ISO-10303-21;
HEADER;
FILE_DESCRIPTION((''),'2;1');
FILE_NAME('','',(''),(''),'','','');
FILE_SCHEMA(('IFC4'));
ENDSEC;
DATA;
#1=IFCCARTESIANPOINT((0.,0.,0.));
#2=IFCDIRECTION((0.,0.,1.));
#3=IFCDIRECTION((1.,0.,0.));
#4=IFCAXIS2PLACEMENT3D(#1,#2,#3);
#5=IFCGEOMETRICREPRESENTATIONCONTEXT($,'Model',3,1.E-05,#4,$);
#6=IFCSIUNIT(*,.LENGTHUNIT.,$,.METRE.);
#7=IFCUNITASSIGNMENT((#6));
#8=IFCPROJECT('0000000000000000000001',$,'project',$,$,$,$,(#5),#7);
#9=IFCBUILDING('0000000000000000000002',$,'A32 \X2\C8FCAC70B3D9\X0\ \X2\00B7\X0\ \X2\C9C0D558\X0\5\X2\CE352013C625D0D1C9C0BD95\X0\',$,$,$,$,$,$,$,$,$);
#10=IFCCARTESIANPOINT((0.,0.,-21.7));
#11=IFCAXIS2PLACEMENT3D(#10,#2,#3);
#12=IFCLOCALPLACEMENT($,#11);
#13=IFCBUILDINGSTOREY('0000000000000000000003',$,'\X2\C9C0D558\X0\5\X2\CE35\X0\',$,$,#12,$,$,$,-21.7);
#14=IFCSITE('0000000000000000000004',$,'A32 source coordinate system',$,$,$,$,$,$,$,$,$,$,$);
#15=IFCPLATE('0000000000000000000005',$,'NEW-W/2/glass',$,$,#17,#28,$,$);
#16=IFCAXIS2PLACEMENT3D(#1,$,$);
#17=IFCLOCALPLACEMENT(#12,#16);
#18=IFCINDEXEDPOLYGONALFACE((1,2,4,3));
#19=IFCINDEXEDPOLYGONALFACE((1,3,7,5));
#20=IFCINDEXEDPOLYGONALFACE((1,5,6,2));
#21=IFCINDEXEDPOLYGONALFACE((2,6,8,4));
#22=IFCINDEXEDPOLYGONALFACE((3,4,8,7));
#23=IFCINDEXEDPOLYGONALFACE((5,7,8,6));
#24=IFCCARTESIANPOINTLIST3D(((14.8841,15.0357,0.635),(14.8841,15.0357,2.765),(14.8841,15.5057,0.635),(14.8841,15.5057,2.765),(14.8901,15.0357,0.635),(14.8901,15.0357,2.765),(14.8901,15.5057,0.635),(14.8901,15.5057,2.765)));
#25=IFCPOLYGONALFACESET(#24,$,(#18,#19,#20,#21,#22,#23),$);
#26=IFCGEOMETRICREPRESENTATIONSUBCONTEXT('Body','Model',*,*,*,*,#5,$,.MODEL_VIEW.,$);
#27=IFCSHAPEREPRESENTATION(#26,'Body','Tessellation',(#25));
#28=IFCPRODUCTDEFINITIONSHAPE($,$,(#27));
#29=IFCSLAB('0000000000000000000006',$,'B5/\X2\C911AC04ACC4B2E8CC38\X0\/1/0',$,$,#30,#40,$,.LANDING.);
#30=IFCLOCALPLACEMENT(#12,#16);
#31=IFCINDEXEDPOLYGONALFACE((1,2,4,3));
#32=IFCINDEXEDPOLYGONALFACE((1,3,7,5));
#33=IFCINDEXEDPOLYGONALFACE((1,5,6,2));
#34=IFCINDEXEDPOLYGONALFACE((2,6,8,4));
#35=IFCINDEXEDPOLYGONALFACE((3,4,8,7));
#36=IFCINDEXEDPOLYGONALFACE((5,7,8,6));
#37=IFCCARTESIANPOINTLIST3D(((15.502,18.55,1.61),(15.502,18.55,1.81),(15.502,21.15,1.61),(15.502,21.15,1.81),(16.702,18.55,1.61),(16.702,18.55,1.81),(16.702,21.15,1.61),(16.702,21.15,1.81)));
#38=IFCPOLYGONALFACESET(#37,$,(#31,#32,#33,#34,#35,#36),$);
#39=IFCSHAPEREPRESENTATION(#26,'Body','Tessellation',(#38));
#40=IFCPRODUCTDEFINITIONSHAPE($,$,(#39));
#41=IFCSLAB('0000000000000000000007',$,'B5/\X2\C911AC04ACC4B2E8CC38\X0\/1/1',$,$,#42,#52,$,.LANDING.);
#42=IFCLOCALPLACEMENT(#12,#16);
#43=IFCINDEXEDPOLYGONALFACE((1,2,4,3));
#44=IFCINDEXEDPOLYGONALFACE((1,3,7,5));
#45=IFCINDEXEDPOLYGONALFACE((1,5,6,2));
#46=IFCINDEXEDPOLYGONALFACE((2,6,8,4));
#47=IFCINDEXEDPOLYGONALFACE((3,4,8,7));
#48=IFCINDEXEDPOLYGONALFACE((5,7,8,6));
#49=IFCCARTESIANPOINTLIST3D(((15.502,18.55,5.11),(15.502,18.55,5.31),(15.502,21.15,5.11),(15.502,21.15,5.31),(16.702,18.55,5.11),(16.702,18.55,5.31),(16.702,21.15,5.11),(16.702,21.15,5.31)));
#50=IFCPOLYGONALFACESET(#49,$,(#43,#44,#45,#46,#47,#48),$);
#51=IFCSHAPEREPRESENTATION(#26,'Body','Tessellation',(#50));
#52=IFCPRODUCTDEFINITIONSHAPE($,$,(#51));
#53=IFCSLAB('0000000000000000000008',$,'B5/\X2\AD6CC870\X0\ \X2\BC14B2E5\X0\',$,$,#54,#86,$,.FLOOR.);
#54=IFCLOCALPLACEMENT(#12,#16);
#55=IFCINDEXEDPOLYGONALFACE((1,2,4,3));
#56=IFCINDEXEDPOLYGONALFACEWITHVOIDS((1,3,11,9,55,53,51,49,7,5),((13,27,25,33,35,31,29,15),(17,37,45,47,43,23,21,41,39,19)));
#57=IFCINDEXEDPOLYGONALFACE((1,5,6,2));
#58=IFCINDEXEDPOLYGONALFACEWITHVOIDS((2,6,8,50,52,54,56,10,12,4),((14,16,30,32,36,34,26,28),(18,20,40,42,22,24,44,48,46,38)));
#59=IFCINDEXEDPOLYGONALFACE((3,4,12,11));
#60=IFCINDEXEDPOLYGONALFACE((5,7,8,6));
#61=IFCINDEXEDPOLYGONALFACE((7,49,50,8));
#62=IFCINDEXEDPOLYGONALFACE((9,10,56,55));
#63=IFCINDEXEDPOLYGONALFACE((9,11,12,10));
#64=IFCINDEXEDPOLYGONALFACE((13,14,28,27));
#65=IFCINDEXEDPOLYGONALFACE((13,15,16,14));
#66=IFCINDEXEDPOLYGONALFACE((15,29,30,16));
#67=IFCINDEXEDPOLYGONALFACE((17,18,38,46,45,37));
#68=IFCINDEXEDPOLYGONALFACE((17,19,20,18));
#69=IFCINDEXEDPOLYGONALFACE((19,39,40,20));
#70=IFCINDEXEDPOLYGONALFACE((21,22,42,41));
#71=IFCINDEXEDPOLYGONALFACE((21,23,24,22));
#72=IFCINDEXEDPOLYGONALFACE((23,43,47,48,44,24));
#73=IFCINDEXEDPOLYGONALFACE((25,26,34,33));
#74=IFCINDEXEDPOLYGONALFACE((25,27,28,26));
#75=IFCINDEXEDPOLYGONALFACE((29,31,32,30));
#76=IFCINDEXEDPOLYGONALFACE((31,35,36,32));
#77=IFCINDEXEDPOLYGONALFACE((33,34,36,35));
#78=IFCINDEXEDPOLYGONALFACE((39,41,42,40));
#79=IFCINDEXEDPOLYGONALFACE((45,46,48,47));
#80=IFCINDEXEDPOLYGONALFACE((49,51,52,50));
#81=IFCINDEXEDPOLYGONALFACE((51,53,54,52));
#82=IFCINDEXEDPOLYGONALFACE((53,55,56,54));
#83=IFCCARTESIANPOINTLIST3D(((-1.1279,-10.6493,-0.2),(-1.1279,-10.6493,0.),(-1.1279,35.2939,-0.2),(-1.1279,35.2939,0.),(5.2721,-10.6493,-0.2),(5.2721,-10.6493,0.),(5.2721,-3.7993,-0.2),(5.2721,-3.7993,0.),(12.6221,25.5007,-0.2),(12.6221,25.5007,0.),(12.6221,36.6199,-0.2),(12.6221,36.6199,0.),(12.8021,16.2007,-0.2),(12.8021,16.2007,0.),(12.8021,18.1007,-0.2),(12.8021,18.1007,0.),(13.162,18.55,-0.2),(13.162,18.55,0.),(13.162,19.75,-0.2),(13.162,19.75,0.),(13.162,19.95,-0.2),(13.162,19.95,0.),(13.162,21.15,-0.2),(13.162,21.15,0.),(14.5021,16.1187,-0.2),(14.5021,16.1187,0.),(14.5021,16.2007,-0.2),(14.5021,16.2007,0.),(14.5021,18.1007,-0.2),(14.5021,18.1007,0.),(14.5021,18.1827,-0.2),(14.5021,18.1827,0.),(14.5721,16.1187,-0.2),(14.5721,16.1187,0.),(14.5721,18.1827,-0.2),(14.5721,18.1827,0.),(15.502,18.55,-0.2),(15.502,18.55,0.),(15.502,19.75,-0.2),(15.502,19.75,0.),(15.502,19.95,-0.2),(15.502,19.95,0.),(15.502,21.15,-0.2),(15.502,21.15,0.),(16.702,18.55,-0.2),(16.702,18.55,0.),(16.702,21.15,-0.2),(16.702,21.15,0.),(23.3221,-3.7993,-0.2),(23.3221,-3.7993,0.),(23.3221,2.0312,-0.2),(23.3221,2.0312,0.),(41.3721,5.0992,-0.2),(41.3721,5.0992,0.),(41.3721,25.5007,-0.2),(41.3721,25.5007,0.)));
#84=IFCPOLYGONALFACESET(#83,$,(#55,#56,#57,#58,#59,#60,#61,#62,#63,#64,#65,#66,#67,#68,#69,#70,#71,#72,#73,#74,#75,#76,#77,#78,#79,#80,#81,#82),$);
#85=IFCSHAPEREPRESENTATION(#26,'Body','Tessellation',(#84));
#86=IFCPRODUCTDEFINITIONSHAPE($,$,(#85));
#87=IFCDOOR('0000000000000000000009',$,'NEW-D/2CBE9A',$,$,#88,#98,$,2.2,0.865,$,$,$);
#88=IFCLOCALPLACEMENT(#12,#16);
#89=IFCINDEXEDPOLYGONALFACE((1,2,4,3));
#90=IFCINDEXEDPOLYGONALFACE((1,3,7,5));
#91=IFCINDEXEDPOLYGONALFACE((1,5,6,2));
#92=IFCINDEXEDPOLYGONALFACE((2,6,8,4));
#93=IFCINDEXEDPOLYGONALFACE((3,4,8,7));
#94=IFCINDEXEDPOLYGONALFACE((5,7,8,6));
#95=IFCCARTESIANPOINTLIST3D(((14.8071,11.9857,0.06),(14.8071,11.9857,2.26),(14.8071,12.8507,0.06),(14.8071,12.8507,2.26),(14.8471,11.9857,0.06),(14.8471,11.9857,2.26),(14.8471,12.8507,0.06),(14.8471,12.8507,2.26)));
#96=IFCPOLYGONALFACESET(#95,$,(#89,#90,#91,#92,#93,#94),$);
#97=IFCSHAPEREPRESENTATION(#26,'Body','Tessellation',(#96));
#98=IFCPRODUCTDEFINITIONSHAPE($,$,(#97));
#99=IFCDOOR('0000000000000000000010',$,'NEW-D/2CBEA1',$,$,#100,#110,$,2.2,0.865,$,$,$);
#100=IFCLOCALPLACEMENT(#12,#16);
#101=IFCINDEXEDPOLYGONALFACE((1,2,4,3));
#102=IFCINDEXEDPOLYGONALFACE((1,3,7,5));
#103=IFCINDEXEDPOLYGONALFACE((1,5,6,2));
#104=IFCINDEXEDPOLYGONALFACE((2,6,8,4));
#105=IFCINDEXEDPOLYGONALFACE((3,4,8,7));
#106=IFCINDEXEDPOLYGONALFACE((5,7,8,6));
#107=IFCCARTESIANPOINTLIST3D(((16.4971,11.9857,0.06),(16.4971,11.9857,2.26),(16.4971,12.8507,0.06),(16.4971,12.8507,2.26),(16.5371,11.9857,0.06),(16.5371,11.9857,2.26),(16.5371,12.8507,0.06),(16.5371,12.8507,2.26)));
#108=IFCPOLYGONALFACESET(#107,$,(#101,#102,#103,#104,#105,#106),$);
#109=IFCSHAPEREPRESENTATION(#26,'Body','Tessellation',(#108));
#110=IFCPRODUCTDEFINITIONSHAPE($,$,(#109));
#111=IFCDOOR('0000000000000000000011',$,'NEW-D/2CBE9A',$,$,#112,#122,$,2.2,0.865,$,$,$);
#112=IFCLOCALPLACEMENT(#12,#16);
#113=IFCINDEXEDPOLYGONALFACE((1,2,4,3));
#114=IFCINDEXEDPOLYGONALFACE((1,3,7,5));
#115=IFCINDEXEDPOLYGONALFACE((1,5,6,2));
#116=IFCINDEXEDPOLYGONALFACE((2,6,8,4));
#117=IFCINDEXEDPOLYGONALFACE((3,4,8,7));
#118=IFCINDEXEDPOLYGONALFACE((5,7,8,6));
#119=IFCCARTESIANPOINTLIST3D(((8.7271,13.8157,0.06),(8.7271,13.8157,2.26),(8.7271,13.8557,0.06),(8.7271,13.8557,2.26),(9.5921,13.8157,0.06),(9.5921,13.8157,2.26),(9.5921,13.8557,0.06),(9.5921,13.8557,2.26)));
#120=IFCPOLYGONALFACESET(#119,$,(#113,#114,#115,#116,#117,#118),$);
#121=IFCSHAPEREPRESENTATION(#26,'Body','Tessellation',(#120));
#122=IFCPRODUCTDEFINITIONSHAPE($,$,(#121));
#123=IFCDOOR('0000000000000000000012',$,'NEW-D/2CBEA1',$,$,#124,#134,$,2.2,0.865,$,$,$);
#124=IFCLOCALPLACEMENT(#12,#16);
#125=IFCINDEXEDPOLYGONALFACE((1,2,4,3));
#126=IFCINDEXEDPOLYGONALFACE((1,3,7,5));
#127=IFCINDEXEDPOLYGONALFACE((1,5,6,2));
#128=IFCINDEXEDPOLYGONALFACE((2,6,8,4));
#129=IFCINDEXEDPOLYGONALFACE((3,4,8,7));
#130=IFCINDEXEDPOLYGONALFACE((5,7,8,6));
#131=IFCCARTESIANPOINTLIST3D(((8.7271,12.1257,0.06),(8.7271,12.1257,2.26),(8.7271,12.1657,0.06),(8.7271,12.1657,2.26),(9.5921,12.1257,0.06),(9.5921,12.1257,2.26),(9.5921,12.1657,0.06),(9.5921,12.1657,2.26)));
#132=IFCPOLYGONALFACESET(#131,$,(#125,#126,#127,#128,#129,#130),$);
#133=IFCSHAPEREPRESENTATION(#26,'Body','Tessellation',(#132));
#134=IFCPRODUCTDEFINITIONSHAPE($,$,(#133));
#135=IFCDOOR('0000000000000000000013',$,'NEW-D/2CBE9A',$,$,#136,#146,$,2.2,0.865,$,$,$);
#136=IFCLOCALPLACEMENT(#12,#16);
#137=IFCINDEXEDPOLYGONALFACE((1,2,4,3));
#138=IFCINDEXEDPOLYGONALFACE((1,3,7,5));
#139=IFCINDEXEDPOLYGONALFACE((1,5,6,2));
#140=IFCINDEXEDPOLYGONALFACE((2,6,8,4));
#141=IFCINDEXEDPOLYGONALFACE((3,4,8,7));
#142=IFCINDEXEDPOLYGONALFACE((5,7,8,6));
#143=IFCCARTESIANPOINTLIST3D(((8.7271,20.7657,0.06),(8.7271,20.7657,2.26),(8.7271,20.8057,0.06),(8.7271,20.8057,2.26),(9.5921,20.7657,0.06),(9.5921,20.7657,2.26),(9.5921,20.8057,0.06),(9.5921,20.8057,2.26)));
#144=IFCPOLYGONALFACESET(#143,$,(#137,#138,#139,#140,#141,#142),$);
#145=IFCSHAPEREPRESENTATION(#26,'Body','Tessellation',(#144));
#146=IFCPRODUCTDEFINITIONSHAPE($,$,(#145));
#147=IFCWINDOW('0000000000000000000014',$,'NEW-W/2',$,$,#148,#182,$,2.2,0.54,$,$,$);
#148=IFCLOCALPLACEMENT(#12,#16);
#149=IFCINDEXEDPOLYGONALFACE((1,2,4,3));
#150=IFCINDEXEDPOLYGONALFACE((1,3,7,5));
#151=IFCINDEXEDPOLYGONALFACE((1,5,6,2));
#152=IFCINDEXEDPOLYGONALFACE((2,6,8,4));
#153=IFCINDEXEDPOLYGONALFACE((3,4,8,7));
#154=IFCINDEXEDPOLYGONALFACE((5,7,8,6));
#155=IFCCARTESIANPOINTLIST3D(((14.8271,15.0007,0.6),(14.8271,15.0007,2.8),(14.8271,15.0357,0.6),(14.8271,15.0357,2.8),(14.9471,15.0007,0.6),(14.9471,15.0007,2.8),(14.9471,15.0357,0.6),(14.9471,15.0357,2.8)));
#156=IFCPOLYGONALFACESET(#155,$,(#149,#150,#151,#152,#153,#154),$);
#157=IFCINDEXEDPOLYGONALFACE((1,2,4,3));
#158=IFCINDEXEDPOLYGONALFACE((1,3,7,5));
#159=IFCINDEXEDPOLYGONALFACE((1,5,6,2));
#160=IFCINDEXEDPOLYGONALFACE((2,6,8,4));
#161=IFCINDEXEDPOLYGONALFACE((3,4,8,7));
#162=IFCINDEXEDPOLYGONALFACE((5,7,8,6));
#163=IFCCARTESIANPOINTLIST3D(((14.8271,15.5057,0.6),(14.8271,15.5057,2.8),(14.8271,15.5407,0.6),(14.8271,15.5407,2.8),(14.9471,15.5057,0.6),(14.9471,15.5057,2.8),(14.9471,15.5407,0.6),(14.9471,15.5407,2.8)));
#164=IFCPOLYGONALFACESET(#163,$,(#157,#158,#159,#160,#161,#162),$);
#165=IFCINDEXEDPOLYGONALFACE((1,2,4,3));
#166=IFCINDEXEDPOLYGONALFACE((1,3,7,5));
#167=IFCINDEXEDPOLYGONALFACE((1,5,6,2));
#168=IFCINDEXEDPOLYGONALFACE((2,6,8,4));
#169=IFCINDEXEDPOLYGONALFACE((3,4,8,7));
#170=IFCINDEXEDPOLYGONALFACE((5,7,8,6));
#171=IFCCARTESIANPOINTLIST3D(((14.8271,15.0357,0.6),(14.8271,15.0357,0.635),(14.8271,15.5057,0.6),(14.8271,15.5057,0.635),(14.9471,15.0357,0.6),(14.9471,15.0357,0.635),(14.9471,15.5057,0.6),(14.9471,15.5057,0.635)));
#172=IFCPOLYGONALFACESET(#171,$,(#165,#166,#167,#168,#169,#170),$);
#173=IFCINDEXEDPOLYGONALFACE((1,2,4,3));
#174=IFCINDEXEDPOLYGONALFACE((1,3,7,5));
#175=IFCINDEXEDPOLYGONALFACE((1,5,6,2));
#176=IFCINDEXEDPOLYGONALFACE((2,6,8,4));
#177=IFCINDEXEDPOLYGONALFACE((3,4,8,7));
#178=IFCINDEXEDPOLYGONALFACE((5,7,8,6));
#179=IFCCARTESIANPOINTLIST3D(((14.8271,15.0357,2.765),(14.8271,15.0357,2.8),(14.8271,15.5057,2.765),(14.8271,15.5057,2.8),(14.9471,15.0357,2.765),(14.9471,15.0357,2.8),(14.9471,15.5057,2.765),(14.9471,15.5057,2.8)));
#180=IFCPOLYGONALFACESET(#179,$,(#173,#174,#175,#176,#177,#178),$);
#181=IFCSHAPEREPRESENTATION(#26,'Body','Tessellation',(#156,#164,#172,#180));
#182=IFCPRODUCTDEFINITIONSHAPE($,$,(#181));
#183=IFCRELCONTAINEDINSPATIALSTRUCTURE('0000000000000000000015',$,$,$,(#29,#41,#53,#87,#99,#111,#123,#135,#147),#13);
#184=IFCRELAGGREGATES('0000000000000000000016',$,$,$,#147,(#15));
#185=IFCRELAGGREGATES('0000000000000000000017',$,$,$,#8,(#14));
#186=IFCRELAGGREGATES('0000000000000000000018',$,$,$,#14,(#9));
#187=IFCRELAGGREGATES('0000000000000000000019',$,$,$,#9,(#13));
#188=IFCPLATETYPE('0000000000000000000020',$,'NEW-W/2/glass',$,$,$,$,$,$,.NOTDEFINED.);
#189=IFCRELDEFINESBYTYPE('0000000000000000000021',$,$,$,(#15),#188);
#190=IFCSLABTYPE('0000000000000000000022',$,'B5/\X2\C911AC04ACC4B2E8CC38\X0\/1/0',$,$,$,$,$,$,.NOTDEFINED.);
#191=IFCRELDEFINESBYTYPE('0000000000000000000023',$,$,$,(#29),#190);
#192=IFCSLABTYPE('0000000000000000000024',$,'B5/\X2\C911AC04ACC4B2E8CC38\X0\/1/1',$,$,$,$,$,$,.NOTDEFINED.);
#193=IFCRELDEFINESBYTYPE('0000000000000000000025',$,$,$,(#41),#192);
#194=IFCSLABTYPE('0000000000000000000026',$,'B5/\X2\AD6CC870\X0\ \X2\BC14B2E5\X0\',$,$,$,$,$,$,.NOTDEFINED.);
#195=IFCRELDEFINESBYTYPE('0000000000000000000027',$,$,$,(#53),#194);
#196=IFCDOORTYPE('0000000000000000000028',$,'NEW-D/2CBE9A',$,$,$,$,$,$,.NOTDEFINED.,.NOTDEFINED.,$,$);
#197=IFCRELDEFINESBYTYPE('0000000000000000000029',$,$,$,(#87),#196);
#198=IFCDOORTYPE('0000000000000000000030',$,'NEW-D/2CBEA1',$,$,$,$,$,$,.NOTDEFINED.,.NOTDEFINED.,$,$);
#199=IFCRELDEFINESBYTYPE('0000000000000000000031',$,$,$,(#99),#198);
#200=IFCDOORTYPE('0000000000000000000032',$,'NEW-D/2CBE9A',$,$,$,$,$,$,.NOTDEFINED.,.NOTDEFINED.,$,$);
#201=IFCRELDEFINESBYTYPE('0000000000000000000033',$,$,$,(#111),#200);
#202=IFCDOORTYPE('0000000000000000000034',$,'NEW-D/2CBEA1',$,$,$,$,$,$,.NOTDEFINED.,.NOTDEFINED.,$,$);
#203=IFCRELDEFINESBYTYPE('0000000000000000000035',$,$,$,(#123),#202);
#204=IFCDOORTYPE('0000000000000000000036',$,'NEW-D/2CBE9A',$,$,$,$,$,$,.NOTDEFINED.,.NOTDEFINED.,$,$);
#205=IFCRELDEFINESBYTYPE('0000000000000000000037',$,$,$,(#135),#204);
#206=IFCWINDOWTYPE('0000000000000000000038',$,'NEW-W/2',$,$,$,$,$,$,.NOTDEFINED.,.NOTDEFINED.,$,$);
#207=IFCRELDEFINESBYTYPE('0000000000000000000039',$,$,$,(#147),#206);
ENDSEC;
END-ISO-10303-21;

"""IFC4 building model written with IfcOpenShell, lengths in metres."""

from ifc_helpers import new_model, si_unit, frame, origin, origin_with_axes, place, context, subcontext, project, spatial, polyline, outline, extrude, source, transform, mapped, type_object, type_shapes, element, aggregate, save


model = new_model("IFC4")

# Units and contexts
model_context = context("Model", 3, precision=1e-05, world=origin_with_axes())
body_context = subcontext(model_context, "Body", "Model", "MODEL_VIEW")
ifc_project = project(units=[si_unit("LENGTHUNIT", "METRE")], contexts=[model_context])

# Plate
plate_type = type_object("IfcPlateType", Name="NEW-W/2/glass", PredefinedType="NOTDEFINED")
shared_shape_1 = source(origin(), body_context, "Body", "SweptSolid", [
    extrude(outline(polyline([(14.8901, 15.0357), (14.8841, 15.0357), (14.8841, 15.5057), (14.8901, 15.5057), (14.8901, 15.0357)])), frame((0.0, 0.0, 0.635)), (0.0, 0.0, 1.0), 2.13),
])
type_shapes(plate_type, [shared_shape_1])
storey_placement = place(None, frame((0.0, 0.0, -21.7), z_axis=(0.0, 0.0, 1.0), x_axis=(1.0, 0.0, 0.0)))
window_placement = place(storey_placement, origin_with_axes())
plate_placement = place(window_placement, origin_with_axes())
plate = element("IfcPlate", 1, at=plate_placement, type_object=plate_type, Name="NEW-W/2/glass", context=body_context, shape_type="MappedRepresentation", body=[
    mapped(shared_shape_1, transform((0.0, 0.0, 0.0), scale=1.0)),
])

# Site, building, storey
site = spatial("IfcSite", under=ifc_project, Name="A32 source coordinate system")
building = spatial("IfcBuilding", under=site, Name="A32 주거동 · 지하5층–옥탑지붕")
storey = spatial("IfcBuildingStorey", under=building, at=storey_placement, Name="지하5층", Elevation=-21.7)

# Slabs
slab_type_1 = type_object("IfcSlabType", Name="B5/중간계단참/1/0", PredefinedType="NOTDEFINED")
shared_shape_2 = source(origin(), body_context, "Body", "SweptSolid", [
    extrude(outline(polyline([(16.702, 18.55), (15.502, 18.55), (15.502, 21.15), (16.702, 21.15), (16.702, 18.55)])), frame((0.0, 0.0, 1.61)), (0.0, 0.0, 1.0), 0.2),
])
type_shapes(slab_type_1, [shared_shape_2])
slab_1_placement = place(storey_placement, origin_with_axes())
element("IfcSlab", 2, at=slab_1_placement, inside=storey, type_object=slab_type_1, Name="B5/중간계단참/1/0", PredefinedType="LANDING", context=body_context, shape_type="MappedRepresentation", body=[
    mapped(shared_shape_2, transform((0.0, 0.0, 0.0), scale=1.0)),
])
slab_type_2 = type_object("IfcSlabType", Name="B5/중간계단참/1/1", PredefinedType="NOTDEFINED")
shared_shape_3 = source(origin(), body_context, "Body", "SweptSolid", [
    extrude(outline(polyline([(16.702, 18.55), (15.502, 18.55), (15.502, 21.15), (16.702, 21.15), (16.702, 18.55)])), frame((0.0, 0.0, 5.11)), (0.0, 0.0, 1.0), 0.2),
])
type_shapes(slab_type_2, [shared_shape_3])
slab_2_placement = place(storey_placement, origin_with_axes())
element("IfcSlab", 3, at=slab_2_placement, inside=storey, type_object=slab_type_2, Name="B5/중간계단참/1/1", PredefinedType="LANDING", context=body_context, shape_type="MappedRepresentation", body=[
    mapped(shared_shape_3, transform((0.0, 0.0, 0.0), scale=1.0)),
])
slab_type_3 = type_object("IfcSlabType", Name="B5/구조 바닥", PredefinedType="NOTDEFINED")
shared_shape_4 = source(origin(), body_context, "Body", "SweptSolid", [
    extrude(outline(polyline([(41.3721, 25.5007), (41.3721, 5.0992), (23.3221, 2.0312), (23.3221, -3.7993), (5.2721, -3.7993), (5.2721, -10.6493), (-1.1279, -10.6493), (-1.1279, 35.2939), (12.6221, 36.6199), (12.6221, 25.5007), (41.3721, 25.5007)]), holes=[polyline([(13.162, 18.55), (15.502, 18.55), (16.702, 18.55), (16.702, 21.15), (15.502, 21.15), (15.502, 21.15), (13.162, 21.15), (13.162, 19.95), (15.502, 19.95), (15.502, 19.75), (13.162, 19.75), (13.162, 18.55)]), polyline([(14.5021, 18.1007), (12.8021, 18.1007), (12.8021, 16.2007), (14.5021, 16.2007), (14.5021, 16.1187), (14.5721, 16.1187), (14.5721, 18.1827), (14.5021, 18.1827), (14.5021, 18.1007)])]), frame((0.0, 0.0, -0.2)), (0.0, 0.0, 1.0), 0.2),
])
type_shapes(slab_type_3, [shared_shape_4])
slab_3_placement = place(storey_placement, origin_with_axes())
element("IfcSlab", 4, at=slab_3_placement, inside=storey, type_object=slab_type_3, Name="B5/구조 바닥", PredefinedType="FLOOR", context=body_context, shape_type="MappedRepresentation", body=[
    mapped(shared_shape_4, transform((0.0, 0.0, 0.0), scale=1.0)),
])

# Doors
door_type_1 = type_object("IfcDoorType", Name="NEW-D/2CBE9A", OperationType="NOTDEFINED", PredefinedType="NOTDEFINED")
shared_shape_5 = source(origin(), body_context, "Body", "SweptSolid", [
    extrude(outline(polyline([(14.8471, 11.9857), (14.8071, 11.9857), (14.8071, 12.8507), (14.8471, 12.8507), (14.8471, 11.9857)])), frame((0.0, 0.0, 0.06)), (0.0, 0.0, 1.0), 2.2),
])
type_shapes(door_type_1, [shared_shape_5])
door_1_placement = place(storey_placement, origin_with_axes())
element("IfcDoor", 5, at=door_1_placement, inside=storey, type_object=door_type_1, Name="NEW-D/2CBE9A", OverallHeight=2.2, OverallWidth=0.865, context=body_context, shape_type="MappedRepresentation", body=[
    mapped(shared_shape_5, transform((0.0, 0.0, 0.0), scale=1.0)),
])
door_type_2 = type_object("IfcDoorType", Name="NEW-D/2CBEA1", OperationType="NOTDEFINED", PredefinedType="NOTDEFINED")
shared_shape_6 = source(origin(), body_context, "Body", "SweptSolid", [
    extrude(outline(polyline([(16.5371, 12.8507), (16.5371, 11.9857), (16.4971, 11.9857), (16.4971, 12.8507), (16.5371, 12.8507)])), frame((0.0, 0.0, 0.06)), (0.0, 0.0, 1.0), 2.2),
])
type_shapes(door_type_2, [shared_shape_6])
door_2_placement = place(storey_placement, origin_with_axes())
element("IfcDoor", 6, at=door_2_placement, inside=storey, type_object=door_type_2, Name="NEW-D/2CBEA1", OverallHeight=2.2, OverallWidth=0.865, context=body_context, shape_type="MappedRepresentation", body=[
    mapped(shared_shape_6, transform((0.0, 0.0, 0.0), scale=1.0)),
])
door_type_3 = type_object("IfcDoorType", Name="NEW-D/2CBE9A", OperationType="NOTDEFINED", PredefinedType="NOTDEFINED")
shared_shape_7 = source(origin(), body_context, "Body", "SweptSolid", [
    extrude(outline(polyline([(8.7271, 13.8157), (8.7271, 13.8557), (9.5921, 13.8557), (9.5921, 13.8157), (8.7271, 13.8157)])), frame((0.0, 0.0, 0.06)), (0.0, 0.0, 1.0), 2.2),
])
type_shapes(door_type_3, [shared_shape_7])
door_3_placement = place(storey_placement, origin_with_axes())
element("IfcDoor", 7, at=door_3_placement, inside=storey, type_object=door_type_3, Name="NEW-D/2CBE9A", OverallHeight=2.2, OverallWidth=0.865, context=body_context, shape_type="MappedRepresentation", body=[
    mapped(shared_shape_7, transform((0.0, 0.0, 0.0), scale=1.0)),
])
door_type_4 = type_object("IfcDoorType", Name="NEW-D/2CBEA1", OperationType="NOTDEFINED", PredefinedType="NOTDEFINED")
shared_shape_8 = source(origin(), body_context, "Body", "SweptSolid", [
    extrude(outline(polyline([(9.5921, 12.1257), (8.7271, 12.1257), (8.7271, 12.1657), (9.5921, 12.1657), (9.5921, 12.1257)])), frame((0.0, 0.0, 0.06)), (0.0, 0.0, 1.0), 2.2),
])
type_shapes(door_type_4, [shared_shape_8])
door_4_placement = place(storey_placement, origin_with_axes())
element("IfcDoor", 8, at=door_4_placement, inside=storey, type_object=door_type_4, Name="NEW-D/2CBEA1", OverallHeight=2.2, OverallWidth=0.865, context=body_context, shape_type="MappedRepresentation", body=[
    mapped(shared_shape_8, transform((0.0, 0.0, 0.0), scale=1.0)),
])
door_type_5 = type_object("IfcDoorType", Name="NEW-D/2CBE9A", OperationType="NOTDEFINED", PredefinedType="NOTDEFINED")
shared_shape_9 = source(origin(), body_context, "Body", "SweptSolid", [
    extrude(outline(polyline([(8.7271, 20.7657), (8.7271, 20.8057), (9.5921, 20.8057), (9.5921, 20.7657), (8.7271, 20.7657)])), frame((0.0, 0.0, 0.06)), (0.0, 0.0, 1.0), 2.2),
])
type_shapes(door_type_5, [shared_shape_9])
door_5_placement = place(storey_placement, origin_with_axes())
element("IfcDoor", 9, at=door_5_placement, inside=storey, type_object=door_type_5, Name="NEW-D/2CBE9A", OverallHeight=2.2, OverallWidth=0.865, context=body_context, shape_type="MappedRepresentation", body=[
    mapped(shared_shape_9, transform((0.0, 0.0, 0.0), scale=1.0)),
])

# Window
window_type = type_object("IfcWindowType", Name="NEW-W/2", PartitioningType="NOTDEFINED", PredefinedType="NOTDEFINED")
shared_shape_10 = source(origin(), body_context, "Body", "SweptSolid", [
    extrude(outline(polyline([(14.8271, 15.0007), (14.8271, 15.0357), (14.9471, 15.0357), (14.9471, 15.0007), (14.8271, 15.0007)])), frame((0.0, 0.0, 0.6)), (0.0, 0.0, 1.0), 2.2),
    extrude(outline(polyline([(14.8271, 15.5057), (14.8271, 15.5407), (14.9471, 15.5407), (14.9471, 15.5057), (14.8271, 15.5057)])), frame((0.0, 0.0, 0.6)), (0.0, 0.0, 1.0), 2.2),
    extrude(outline(polyline([(14.9471, 15.0357), (14.9471, 15.5057), (14.8271, 15.5057), (14.8271, 15.0357), (14.9471, 15.0357)])), frame((0.0, 0.0, 0.6)), (0.0, 0.0, 1.0), 0.035),
    extrude(outline(polyline([(14.9471, 15.0357), (14.9471, 15.5057), (14.8271, 15.5057), (14.8271, 15.0357), (14.9471, 15.0357)])), frame((0.0, 0.0, 2.765)), (0.0, 0.0, 1.0), 0.035),
])
type_shapes(window_type, [shared_shape_10])
window = element("IfcWindow", 10, at=window_placement, inside=storey, type_object=window_type, Name="NEW-W/2", OverallHeight=2.2, OverallWidth=0.54, context=body_context, shape_type="MappedRepresentation", body=[
    mapped(shared_shape_10, transform((0.0, 0.0, 0.0), scale=1.0)),
])
aggregate(window, [plate])

save(model, "model.ifc")
